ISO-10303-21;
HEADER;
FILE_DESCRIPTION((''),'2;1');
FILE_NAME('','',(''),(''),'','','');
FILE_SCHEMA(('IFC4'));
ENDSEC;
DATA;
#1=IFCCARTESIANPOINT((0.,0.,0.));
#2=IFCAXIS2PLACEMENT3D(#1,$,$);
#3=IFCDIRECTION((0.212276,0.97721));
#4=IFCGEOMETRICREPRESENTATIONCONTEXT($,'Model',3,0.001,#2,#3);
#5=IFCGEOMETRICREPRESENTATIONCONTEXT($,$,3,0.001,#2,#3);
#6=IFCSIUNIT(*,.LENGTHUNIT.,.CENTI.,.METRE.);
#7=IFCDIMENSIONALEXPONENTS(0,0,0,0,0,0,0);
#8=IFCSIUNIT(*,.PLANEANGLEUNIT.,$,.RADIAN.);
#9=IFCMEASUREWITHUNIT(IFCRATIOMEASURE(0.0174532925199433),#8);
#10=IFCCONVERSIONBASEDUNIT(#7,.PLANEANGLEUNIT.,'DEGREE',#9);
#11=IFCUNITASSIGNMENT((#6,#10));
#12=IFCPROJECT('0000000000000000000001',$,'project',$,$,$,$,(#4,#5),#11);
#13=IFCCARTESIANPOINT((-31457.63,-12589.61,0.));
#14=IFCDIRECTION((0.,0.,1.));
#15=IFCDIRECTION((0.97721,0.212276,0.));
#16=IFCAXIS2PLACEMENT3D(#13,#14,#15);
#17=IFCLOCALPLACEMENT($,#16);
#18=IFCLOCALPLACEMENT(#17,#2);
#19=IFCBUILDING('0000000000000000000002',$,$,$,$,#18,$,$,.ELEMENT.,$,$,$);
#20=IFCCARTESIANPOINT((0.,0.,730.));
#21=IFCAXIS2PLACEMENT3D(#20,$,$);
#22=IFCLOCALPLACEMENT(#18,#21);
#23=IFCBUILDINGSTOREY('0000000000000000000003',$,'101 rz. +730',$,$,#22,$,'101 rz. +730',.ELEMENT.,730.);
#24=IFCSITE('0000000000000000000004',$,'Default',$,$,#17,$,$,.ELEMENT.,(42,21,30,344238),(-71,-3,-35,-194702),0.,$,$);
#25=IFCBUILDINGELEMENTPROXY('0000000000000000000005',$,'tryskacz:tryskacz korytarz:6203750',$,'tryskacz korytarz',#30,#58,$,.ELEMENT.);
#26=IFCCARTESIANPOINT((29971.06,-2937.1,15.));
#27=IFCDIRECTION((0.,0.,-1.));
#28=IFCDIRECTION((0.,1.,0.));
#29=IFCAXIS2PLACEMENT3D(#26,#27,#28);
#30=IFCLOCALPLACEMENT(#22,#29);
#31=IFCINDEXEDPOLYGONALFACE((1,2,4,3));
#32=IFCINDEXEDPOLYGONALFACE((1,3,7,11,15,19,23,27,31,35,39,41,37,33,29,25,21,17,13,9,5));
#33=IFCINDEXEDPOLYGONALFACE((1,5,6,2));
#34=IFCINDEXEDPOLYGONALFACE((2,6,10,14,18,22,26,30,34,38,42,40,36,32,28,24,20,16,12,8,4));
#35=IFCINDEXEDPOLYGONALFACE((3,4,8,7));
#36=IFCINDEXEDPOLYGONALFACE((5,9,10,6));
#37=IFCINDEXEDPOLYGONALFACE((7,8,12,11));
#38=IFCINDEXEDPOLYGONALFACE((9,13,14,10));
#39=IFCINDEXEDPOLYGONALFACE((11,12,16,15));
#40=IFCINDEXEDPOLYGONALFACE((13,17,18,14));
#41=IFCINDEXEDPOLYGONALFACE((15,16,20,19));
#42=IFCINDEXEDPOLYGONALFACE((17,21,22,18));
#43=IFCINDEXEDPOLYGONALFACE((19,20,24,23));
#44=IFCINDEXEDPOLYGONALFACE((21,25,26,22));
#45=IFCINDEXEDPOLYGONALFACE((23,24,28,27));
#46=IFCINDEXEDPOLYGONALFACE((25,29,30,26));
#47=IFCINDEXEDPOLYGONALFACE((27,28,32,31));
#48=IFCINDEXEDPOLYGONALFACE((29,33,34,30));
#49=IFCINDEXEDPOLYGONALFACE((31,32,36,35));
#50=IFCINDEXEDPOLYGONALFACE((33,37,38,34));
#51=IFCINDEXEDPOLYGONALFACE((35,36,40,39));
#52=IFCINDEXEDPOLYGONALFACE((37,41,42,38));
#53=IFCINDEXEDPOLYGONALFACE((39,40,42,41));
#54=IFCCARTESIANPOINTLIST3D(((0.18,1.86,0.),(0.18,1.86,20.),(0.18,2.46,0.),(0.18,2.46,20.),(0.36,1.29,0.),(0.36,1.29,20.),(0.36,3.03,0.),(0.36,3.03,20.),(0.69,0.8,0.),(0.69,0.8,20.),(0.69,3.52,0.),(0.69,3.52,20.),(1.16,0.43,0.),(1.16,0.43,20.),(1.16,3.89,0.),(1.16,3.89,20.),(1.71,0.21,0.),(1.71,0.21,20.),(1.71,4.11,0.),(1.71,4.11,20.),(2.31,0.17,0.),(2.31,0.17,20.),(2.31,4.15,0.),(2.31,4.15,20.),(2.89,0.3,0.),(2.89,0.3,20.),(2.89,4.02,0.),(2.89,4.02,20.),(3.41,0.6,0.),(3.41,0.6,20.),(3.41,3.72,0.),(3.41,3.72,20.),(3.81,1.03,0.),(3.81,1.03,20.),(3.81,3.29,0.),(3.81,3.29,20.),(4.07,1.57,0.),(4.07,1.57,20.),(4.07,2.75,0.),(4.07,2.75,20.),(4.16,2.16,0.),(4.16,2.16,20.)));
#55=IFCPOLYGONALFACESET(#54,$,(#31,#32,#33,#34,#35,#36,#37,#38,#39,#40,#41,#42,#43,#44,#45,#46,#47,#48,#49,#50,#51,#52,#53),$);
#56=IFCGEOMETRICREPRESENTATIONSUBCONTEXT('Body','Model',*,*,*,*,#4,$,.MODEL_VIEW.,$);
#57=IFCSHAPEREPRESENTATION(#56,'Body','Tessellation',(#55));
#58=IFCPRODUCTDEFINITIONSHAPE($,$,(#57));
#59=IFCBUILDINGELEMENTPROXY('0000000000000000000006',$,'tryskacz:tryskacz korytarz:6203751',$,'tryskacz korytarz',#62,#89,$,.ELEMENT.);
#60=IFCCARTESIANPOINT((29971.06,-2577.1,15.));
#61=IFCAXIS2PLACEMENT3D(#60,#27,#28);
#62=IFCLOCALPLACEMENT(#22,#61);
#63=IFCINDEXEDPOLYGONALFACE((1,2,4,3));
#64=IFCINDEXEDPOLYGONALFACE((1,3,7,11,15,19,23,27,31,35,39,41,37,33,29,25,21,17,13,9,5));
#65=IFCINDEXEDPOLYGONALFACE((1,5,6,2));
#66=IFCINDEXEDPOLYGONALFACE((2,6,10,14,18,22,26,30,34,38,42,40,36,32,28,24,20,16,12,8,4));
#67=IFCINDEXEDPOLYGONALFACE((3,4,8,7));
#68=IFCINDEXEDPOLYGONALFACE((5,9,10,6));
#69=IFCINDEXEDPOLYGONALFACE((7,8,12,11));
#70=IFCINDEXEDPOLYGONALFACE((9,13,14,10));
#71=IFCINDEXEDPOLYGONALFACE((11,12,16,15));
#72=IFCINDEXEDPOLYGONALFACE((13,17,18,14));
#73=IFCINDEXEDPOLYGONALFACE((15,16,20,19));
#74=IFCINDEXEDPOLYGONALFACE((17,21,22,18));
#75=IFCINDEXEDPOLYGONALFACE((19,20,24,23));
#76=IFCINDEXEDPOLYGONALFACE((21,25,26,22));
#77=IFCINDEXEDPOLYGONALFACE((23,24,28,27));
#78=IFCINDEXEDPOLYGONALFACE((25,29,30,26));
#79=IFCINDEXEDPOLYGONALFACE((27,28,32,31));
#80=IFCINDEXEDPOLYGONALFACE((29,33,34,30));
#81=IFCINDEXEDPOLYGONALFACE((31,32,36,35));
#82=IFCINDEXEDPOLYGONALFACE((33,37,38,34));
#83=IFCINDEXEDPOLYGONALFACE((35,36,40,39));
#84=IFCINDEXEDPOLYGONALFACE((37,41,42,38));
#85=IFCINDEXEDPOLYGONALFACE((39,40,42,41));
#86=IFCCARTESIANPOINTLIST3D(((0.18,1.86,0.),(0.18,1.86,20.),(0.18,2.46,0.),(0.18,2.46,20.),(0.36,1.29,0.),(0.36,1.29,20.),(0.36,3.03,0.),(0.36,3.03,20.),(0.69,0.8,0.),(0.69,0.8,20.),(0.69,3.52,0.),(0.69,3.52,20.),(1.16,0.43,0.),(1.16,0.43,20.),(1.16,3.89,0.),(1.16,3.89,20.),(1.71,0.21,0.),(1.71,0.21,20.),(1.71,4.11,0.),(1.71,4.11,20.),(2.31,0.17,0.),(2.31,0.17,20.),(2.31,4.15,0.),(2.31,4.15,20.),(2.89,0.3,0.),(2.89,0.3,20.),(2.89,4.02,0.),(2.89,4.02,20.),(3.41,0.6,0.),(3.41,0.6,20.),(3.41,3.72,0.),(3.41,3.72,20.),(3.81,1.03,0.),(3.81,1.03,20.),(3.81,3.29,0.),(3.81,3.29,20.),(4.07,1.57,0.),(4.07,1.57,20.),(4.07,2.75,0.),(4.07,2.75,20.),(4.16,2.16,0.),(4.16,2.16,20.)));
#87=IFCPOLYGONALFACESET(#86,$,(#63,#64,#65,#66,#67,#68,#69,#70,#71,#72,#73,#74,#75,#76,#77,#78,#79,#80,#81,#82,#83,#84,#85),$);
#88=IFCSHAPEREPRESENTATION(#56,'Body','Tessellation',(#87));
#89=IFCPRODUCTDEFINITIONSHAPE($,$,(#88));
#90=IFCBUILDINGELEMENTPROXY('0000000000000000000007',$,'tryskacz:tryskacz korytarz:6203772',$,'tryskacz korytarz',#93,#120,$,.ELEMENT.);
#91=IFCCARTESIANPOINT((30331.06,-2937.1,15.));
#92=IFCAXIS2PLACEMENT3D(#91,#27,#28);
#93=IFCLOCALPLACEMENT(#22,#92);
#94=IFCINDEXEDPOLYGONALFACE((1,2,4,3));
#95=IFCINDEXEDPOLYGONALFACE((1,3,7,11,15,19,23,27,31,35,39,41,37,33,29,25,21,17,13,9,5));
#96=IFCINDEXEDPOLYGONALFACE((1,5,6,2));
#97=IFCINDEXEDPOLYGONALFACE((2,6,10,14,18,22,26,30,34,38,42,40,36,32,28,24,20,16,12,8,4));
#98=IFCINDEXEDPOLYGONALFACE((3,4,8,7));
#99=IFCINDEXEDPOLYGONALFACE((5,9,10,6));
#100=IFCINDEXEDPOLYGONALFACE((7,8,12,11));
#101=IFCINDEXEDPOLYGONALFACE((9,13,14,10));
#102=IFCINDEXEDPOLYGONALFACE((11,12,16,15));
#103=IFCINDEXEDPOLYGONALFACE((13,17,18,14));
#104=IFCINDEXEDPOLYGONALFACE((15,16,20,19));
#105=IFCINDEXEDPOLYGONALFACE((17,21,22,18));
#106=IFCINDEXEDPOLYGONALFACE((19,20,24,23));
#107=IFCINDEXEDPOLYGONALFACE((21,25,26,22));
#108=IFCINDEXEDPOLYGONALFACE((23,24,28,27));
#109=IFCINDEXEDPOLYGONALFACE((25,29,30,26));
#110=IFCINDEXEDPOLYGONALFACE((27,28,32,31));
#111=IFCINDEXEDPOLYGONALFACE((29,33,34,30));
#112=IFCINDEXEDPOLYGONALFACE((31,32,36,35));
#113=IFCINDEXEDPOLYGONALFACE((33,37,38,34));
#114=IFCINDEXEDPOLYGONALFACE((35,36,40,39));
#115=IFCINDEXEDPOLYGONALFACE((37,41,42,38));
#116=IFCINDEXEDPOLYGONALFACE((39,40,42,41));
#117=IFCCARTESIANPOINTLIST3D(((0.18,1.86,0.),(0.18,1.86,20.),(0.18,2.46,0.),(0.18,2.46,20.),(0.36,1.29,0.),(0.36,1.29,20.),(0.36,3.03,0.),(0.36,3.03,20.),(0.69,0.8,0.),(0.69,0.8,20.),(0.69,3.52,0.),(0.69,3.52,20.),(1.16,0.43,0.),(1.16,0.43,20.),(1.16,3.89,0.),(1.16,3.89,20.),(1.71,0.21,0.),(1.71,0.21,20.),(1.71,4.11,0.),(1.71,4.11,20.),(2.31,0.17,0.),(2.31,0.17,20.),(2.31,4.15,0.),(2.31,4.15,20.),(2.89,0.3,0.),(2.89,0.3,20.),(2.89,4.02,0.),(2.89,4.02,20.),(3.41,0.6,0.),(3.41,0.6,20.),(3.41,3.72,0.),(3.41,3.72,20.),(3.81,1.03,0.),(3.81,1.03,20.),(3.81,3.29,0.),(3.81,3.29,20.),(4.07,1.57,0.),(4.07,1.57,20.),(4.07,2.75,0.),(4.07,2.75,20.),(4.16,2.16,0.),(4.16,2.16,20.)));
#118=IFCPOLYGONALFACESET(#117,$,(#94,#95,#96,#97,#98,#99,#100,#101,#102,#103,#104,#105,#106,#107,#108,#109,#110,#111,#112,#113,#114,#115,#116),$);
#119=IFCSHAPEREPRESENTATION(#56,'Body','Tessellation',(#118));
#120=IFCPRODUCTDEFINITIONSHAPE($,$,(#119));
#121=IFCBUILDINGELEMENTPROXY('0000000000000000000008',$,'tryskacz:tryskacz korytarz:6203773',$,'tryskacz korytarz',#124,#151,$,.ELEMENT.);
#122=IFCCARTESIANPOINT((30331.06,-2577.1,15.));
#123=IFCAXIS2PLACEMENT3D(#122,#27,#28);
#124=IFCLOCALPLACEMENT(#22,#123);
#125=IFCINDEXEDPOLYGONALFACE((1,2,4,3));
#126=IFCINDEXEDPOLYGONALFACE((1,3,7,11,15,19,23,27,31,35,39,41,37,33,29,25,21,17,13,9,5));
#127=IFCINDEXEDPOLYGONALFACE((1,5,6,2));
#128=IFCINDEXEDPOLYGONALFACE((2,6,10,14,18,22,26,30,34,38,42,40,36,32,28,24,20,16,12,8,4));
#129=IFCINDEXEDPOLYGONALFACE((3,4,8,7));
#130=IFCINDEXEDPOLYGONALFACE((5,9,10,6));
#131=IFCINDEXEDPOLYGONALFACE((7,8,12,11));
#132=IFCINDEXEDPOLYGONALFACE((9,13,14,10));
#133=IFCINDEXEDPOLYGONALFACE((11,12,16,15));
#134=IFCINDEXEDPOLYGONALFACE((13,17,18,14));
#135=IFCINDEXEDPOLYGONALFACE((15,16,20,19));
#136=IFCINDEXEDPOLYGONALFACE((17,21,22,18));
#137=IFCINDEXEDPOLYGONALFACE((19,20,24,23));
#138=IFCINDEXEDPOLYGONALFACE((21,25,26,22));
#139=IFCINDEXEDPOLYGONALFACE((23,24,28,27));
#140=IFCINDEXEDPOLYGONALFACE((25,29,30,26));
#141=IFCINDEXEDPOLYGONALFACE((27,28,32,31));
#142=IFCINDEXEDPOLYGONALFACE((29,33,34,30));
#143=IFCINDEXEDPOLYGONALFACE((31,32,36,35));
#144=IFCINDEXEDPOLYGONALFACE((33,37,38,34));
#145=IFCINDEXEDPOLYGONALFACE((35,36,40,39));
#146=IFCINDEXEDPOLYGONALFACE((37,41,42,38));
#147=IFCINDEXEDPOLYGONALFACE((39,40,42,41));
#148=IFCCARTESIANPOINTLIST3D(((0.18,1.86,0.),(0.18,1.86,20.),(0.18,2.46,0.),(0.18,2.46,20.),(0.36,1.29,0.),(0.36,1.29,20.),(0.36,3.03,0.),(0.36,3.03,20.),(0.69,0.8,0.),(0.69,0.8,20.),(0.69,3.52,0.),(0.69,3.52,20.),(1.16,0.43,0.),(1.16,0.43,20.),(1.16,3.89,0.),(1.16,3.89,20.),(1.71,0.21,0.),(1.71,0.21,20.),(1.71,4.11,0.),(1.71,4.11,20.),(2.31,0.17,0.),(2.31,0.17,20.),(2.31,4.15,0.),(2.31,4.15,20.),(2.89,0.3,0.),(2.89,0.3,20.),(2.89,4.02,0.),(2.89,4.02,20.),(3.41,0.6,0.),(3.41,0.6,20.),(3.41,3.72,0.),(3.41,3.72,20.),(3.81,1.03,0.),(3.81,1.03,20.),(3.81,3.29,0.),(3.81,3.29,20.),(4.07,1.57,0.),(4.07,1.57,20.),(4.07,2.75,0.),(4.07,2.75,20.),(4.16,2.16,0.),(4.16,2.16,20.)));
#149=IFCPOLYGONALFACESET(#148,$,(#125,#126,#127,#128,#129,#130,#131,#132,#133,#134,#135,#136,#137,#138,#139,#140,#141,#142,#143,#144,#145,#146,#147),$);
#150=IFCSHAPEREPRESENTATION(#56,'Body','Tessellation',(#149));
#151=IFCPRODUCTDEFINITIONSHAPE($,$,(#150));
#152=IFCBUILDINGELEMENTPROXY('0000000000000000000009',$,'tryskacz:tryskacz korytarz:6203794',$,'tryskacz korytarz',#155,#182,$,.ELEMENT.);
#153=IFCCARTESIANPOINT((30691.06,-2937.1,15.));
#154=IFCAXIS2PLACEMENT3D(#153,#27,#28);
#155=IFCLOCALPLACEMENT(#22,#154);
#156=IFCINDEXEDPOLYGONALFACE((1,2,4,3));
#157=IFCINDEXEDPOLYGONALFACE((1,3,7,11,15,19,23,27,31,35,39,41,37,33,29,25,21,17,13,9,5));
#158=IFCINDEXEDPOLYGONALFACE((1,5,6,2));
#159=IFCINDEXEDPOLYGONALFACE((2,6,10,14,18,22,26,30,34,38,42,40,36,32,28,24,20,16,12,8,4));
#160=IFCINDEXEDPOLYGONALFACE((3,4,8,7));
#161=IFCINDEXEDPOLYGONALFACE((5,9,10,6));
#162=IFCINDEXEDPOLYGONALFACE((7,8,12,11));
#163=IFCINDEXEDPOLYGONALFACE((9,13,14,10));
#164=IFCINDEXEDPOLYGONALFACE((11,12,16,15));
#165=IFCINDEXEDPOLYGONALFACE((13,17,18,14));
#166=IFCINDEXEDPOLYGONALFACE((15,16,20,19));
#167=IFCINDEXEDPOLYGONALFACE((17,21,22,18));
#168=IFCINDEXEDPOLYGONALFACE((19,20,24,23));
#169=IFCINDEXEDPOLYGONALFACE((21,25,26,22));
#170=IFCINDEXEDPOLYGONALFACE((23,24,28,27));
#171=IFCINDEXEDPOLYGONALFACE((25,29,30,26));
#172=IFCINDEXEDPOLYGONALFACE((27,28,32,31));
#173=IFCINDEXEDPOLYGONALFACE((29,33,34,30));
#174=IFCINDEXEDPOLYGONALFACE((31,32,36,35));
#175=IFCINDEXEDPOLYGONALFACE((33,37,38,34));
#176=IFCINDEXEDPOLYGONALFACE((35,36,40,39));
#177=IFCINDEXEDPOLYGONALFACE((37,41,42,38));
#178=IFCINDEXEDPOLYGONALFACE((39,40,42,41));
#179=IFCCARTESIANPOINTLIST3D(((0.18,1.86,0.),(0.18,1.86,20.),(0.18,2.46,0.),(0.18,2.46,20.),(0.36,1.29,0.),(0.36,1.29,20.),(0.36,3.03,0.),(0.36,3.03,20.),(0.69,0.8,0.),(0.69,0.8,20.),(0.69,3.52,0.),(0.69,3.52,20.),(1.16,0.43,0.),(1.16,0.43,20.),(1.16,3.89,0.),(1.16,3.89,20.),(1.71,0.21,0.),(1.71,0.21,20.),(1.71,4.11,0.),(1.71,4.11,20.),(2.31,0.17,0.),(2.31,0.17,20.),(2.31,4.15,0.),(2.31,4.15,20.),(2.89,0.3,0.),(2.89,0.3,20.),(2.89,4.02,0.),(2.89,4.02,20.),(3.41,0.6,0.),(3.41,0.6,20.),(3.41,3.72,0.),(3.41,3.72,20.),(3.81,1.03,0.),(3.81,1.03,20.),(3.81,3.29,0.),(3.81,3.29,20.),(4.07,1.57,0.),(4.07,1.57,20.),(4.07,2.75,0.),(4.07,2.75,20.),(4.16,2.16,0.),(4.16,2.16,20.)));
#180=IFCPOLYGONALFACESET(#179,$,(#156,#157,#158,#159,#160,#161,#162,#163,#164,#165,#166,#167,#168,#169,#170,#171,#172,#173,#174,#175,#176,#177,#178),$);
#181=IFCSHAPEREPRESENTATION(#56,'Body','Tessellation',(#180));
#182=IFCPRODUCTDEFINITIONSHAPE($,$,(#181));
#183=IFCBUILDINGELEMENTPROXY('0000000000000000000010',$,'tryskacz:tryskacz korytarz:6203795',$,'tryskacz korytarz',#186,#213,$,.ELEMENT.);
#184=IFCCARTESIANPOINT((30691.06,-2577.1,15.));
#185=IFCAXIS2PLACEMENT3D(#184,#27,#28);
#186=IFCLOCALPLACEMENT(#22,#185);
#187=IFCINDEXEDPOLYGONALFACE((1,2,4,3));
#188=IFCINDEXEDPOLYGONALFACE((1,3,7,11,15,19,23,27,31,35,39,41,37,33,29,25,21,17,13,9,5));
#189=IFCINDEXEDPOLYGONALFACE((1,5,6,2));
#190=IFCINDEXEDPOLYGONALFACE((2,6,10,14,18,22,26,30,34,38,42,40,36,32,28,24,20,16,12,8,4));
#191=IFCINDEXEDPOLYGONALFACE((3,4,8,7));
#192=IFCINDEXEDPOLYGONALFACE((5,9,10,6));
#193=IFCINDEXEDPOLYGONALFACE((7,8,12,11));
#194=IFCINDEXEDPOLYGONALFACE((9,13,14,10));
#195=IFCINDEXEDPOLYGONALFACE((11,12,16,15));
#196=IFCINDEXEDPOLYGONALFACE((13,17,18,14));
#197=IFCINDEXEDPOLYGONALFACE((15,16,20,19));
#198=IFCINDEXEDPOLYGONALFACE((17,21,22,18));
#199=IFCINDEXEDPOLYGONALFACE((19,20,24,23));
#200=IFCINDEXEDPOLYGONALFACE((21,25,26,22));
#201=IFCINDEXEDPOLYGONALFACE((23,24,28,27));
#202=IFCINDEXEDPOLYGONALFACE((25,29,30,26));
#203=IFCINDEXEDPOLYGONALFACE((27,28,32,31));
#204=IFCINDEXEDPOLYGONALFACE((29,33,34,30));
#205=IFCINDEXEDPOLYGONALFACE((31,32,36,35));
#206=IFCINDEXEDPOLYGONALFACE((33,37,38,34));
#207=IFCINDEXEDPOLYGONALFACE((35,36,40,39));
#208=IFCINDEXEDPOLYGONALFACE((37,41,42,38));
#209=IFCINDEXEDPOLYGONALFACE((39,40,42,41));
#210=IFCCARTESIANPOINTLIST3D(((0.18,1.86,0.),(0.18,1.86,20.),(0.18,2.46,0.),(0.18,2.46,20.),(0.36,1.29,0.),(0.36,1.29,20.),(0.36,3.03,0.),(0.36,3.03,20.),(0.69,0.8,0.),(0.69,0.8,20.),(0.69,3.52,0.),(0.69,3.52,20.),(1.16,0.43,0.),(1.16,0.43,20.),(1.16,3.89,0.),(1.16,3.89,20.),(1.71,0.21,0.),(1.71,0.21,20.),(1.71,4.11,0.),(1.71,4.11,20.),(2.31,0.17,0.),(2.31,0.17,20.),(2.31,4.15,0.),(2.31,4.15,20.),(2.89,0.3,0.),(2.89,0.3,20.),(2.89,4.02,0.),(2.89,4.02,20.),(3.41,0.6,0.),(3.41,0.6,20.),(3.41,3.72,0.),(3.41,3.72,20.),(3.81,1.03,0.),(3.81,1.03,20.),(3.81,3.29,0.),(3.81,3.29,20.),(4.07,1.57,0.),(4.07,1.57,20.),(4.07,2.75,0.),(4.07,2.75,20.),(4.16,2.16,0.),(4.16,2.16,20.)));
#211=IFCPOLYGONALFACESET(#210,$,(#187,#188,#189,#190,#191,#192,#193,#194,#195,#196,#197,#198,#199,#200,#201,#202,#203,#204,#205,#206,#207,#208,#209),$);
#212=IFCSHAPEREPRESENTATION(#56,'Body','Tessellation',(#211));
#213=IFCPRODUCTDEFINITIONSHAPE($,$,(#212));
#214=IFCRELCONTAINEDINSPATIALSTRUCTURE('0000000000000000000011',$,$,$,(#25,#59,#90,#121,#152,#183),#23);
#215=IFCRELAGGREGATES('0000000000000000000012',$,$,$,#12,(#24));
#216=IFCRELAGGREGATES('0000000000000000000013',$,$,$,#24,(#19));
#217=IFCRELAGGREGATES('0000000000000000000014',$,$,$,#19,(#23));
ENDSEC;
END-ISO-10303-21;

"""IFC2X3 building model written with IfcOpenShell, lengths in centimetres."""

from ifc_helpers import new_model, entity, si_unit, converted_unit, direction, frame, frame_2d, origin, place, context, subcontext, project, spatial, circle, extrude, source, transform, mapped, element, save


model = new_model("IFC2X3")

# Units and contexts
model_context = context("Model", 3, precision=0.001, world=origin(), true_north=direction((0.212276, 0.97721)))
context_of_model = context(None, 3, precision=0.001, world=origin(), true_north=direction((0.212276, 0.97721)))
body_context = subcontext(model_context, "Body", "Model", "MODEL_VIEW")
ifc_project = project(units=[si_unit("LENGTHUNIT", "METRE", prefix="CENTI"), converted_unit("PLANEANGLEUNIT", "DEGREE", entity("IfcRatioMeasure", 0.0174532925199433), si_unit("PLANEANGLEUNIT", "RADIAN"), dimensions=[0, 0, 0, 0, 0, 0, 0])], contexts=[model_context, context_of_model])

# Site, building, storey
site_placement = place(None, frame((-31457.63, -12589.61, 0.0), z_axis=(0.0, 0.0, 1.0), x_axis=(0.97721, 0.212276, 0.0)))
site = spatial("IfcSite", under=ifc_project, at=site_placement, Name="Default", CompositionType="ELEMENT", RefLatitude=(42, 21, 30, 344238), RefLongitude=(-71, -3, -35, -194702), RefElevation=0.0)
building_placement = place(site_placement, origin())
building = spatial("IfcBuilding", under=site, at=building_placement, CompositionType="ELEMENT")
storey_placement = place(building_placement, frame((0.0, 0.0, 730.0)))
storey = spatial("IfcBuildingStorey", under=building, at=storey_placement, Name="101 rz. +730", LongName="101 rz. +730", CompositionType="ELEMENT", Elevation=730.0)

# Building element proxies
shared_shape_1 = source(origin(), body_context, "Body", "SweptSolid", [
    extrude(circle(Radius=2.0, at=frame_2d((0.0, 0.0), x_axis=(1.0, 0.0))), frame((2.16, 2.16, 0.0)), (0.0, 0.0, 1.0), 20.0),
])
for number, where, z_axis, x_axis, name in (
    (1, (29971.06, -2937.1, 15.0), (0.0, 0.0, -1.0), (0.0, 1.0, 0.0), "tryskacz:tryskacz korytarz:6203750"),
    (2, (29971.06, -2577.1, 15.0), (0.0, 0.0, -1.0), (0.0, 1.0, 0.0), "tryskacz:tryskacz korytarz:6203751"),
    (3, (30331.06, -2937.1, 15.0), (0.0, 0.0, -1.0), (0.0, 1.0, 0.0), "tryskacz:tryskacz korytarz:6203772"),
    (4, (30331.06, -2577.1, 15.0), (0.0, 0.0, -1.0), (0.0, 1.0, 0.0), "tryskacz:tryskacz korytarz:6203773"),
    (5, (30691.06, -2937.1, 15.0), (0.0, 0.0, -1.0), (0.0, 1.0, 0.0), "tryskacz:tryskacz korytarz:6203794"),
    (6, (30691.06, -2577.1, 15.0), (0.0, 0.0, -1.0), (0.0, 1.0, 0.0), "tryskacz:tryskacz korytarz:6203795"),
):
    element("IfcBuildingElementProxy", number, at=place(storey_placement, frame(where, z_axis=z_axis, x_axis=x_axis)), inside=storey, Name=name, ObjectType="tryskacz korytarz", CompositionType="ELEMENT", context=body_context, shape_type="MappedRepresentation", body=[
        mapped(shared_shape_1, transform((0.0, 0.0, 0.0), scale=1.0)),
    ])

save(model, "model.ifc")
